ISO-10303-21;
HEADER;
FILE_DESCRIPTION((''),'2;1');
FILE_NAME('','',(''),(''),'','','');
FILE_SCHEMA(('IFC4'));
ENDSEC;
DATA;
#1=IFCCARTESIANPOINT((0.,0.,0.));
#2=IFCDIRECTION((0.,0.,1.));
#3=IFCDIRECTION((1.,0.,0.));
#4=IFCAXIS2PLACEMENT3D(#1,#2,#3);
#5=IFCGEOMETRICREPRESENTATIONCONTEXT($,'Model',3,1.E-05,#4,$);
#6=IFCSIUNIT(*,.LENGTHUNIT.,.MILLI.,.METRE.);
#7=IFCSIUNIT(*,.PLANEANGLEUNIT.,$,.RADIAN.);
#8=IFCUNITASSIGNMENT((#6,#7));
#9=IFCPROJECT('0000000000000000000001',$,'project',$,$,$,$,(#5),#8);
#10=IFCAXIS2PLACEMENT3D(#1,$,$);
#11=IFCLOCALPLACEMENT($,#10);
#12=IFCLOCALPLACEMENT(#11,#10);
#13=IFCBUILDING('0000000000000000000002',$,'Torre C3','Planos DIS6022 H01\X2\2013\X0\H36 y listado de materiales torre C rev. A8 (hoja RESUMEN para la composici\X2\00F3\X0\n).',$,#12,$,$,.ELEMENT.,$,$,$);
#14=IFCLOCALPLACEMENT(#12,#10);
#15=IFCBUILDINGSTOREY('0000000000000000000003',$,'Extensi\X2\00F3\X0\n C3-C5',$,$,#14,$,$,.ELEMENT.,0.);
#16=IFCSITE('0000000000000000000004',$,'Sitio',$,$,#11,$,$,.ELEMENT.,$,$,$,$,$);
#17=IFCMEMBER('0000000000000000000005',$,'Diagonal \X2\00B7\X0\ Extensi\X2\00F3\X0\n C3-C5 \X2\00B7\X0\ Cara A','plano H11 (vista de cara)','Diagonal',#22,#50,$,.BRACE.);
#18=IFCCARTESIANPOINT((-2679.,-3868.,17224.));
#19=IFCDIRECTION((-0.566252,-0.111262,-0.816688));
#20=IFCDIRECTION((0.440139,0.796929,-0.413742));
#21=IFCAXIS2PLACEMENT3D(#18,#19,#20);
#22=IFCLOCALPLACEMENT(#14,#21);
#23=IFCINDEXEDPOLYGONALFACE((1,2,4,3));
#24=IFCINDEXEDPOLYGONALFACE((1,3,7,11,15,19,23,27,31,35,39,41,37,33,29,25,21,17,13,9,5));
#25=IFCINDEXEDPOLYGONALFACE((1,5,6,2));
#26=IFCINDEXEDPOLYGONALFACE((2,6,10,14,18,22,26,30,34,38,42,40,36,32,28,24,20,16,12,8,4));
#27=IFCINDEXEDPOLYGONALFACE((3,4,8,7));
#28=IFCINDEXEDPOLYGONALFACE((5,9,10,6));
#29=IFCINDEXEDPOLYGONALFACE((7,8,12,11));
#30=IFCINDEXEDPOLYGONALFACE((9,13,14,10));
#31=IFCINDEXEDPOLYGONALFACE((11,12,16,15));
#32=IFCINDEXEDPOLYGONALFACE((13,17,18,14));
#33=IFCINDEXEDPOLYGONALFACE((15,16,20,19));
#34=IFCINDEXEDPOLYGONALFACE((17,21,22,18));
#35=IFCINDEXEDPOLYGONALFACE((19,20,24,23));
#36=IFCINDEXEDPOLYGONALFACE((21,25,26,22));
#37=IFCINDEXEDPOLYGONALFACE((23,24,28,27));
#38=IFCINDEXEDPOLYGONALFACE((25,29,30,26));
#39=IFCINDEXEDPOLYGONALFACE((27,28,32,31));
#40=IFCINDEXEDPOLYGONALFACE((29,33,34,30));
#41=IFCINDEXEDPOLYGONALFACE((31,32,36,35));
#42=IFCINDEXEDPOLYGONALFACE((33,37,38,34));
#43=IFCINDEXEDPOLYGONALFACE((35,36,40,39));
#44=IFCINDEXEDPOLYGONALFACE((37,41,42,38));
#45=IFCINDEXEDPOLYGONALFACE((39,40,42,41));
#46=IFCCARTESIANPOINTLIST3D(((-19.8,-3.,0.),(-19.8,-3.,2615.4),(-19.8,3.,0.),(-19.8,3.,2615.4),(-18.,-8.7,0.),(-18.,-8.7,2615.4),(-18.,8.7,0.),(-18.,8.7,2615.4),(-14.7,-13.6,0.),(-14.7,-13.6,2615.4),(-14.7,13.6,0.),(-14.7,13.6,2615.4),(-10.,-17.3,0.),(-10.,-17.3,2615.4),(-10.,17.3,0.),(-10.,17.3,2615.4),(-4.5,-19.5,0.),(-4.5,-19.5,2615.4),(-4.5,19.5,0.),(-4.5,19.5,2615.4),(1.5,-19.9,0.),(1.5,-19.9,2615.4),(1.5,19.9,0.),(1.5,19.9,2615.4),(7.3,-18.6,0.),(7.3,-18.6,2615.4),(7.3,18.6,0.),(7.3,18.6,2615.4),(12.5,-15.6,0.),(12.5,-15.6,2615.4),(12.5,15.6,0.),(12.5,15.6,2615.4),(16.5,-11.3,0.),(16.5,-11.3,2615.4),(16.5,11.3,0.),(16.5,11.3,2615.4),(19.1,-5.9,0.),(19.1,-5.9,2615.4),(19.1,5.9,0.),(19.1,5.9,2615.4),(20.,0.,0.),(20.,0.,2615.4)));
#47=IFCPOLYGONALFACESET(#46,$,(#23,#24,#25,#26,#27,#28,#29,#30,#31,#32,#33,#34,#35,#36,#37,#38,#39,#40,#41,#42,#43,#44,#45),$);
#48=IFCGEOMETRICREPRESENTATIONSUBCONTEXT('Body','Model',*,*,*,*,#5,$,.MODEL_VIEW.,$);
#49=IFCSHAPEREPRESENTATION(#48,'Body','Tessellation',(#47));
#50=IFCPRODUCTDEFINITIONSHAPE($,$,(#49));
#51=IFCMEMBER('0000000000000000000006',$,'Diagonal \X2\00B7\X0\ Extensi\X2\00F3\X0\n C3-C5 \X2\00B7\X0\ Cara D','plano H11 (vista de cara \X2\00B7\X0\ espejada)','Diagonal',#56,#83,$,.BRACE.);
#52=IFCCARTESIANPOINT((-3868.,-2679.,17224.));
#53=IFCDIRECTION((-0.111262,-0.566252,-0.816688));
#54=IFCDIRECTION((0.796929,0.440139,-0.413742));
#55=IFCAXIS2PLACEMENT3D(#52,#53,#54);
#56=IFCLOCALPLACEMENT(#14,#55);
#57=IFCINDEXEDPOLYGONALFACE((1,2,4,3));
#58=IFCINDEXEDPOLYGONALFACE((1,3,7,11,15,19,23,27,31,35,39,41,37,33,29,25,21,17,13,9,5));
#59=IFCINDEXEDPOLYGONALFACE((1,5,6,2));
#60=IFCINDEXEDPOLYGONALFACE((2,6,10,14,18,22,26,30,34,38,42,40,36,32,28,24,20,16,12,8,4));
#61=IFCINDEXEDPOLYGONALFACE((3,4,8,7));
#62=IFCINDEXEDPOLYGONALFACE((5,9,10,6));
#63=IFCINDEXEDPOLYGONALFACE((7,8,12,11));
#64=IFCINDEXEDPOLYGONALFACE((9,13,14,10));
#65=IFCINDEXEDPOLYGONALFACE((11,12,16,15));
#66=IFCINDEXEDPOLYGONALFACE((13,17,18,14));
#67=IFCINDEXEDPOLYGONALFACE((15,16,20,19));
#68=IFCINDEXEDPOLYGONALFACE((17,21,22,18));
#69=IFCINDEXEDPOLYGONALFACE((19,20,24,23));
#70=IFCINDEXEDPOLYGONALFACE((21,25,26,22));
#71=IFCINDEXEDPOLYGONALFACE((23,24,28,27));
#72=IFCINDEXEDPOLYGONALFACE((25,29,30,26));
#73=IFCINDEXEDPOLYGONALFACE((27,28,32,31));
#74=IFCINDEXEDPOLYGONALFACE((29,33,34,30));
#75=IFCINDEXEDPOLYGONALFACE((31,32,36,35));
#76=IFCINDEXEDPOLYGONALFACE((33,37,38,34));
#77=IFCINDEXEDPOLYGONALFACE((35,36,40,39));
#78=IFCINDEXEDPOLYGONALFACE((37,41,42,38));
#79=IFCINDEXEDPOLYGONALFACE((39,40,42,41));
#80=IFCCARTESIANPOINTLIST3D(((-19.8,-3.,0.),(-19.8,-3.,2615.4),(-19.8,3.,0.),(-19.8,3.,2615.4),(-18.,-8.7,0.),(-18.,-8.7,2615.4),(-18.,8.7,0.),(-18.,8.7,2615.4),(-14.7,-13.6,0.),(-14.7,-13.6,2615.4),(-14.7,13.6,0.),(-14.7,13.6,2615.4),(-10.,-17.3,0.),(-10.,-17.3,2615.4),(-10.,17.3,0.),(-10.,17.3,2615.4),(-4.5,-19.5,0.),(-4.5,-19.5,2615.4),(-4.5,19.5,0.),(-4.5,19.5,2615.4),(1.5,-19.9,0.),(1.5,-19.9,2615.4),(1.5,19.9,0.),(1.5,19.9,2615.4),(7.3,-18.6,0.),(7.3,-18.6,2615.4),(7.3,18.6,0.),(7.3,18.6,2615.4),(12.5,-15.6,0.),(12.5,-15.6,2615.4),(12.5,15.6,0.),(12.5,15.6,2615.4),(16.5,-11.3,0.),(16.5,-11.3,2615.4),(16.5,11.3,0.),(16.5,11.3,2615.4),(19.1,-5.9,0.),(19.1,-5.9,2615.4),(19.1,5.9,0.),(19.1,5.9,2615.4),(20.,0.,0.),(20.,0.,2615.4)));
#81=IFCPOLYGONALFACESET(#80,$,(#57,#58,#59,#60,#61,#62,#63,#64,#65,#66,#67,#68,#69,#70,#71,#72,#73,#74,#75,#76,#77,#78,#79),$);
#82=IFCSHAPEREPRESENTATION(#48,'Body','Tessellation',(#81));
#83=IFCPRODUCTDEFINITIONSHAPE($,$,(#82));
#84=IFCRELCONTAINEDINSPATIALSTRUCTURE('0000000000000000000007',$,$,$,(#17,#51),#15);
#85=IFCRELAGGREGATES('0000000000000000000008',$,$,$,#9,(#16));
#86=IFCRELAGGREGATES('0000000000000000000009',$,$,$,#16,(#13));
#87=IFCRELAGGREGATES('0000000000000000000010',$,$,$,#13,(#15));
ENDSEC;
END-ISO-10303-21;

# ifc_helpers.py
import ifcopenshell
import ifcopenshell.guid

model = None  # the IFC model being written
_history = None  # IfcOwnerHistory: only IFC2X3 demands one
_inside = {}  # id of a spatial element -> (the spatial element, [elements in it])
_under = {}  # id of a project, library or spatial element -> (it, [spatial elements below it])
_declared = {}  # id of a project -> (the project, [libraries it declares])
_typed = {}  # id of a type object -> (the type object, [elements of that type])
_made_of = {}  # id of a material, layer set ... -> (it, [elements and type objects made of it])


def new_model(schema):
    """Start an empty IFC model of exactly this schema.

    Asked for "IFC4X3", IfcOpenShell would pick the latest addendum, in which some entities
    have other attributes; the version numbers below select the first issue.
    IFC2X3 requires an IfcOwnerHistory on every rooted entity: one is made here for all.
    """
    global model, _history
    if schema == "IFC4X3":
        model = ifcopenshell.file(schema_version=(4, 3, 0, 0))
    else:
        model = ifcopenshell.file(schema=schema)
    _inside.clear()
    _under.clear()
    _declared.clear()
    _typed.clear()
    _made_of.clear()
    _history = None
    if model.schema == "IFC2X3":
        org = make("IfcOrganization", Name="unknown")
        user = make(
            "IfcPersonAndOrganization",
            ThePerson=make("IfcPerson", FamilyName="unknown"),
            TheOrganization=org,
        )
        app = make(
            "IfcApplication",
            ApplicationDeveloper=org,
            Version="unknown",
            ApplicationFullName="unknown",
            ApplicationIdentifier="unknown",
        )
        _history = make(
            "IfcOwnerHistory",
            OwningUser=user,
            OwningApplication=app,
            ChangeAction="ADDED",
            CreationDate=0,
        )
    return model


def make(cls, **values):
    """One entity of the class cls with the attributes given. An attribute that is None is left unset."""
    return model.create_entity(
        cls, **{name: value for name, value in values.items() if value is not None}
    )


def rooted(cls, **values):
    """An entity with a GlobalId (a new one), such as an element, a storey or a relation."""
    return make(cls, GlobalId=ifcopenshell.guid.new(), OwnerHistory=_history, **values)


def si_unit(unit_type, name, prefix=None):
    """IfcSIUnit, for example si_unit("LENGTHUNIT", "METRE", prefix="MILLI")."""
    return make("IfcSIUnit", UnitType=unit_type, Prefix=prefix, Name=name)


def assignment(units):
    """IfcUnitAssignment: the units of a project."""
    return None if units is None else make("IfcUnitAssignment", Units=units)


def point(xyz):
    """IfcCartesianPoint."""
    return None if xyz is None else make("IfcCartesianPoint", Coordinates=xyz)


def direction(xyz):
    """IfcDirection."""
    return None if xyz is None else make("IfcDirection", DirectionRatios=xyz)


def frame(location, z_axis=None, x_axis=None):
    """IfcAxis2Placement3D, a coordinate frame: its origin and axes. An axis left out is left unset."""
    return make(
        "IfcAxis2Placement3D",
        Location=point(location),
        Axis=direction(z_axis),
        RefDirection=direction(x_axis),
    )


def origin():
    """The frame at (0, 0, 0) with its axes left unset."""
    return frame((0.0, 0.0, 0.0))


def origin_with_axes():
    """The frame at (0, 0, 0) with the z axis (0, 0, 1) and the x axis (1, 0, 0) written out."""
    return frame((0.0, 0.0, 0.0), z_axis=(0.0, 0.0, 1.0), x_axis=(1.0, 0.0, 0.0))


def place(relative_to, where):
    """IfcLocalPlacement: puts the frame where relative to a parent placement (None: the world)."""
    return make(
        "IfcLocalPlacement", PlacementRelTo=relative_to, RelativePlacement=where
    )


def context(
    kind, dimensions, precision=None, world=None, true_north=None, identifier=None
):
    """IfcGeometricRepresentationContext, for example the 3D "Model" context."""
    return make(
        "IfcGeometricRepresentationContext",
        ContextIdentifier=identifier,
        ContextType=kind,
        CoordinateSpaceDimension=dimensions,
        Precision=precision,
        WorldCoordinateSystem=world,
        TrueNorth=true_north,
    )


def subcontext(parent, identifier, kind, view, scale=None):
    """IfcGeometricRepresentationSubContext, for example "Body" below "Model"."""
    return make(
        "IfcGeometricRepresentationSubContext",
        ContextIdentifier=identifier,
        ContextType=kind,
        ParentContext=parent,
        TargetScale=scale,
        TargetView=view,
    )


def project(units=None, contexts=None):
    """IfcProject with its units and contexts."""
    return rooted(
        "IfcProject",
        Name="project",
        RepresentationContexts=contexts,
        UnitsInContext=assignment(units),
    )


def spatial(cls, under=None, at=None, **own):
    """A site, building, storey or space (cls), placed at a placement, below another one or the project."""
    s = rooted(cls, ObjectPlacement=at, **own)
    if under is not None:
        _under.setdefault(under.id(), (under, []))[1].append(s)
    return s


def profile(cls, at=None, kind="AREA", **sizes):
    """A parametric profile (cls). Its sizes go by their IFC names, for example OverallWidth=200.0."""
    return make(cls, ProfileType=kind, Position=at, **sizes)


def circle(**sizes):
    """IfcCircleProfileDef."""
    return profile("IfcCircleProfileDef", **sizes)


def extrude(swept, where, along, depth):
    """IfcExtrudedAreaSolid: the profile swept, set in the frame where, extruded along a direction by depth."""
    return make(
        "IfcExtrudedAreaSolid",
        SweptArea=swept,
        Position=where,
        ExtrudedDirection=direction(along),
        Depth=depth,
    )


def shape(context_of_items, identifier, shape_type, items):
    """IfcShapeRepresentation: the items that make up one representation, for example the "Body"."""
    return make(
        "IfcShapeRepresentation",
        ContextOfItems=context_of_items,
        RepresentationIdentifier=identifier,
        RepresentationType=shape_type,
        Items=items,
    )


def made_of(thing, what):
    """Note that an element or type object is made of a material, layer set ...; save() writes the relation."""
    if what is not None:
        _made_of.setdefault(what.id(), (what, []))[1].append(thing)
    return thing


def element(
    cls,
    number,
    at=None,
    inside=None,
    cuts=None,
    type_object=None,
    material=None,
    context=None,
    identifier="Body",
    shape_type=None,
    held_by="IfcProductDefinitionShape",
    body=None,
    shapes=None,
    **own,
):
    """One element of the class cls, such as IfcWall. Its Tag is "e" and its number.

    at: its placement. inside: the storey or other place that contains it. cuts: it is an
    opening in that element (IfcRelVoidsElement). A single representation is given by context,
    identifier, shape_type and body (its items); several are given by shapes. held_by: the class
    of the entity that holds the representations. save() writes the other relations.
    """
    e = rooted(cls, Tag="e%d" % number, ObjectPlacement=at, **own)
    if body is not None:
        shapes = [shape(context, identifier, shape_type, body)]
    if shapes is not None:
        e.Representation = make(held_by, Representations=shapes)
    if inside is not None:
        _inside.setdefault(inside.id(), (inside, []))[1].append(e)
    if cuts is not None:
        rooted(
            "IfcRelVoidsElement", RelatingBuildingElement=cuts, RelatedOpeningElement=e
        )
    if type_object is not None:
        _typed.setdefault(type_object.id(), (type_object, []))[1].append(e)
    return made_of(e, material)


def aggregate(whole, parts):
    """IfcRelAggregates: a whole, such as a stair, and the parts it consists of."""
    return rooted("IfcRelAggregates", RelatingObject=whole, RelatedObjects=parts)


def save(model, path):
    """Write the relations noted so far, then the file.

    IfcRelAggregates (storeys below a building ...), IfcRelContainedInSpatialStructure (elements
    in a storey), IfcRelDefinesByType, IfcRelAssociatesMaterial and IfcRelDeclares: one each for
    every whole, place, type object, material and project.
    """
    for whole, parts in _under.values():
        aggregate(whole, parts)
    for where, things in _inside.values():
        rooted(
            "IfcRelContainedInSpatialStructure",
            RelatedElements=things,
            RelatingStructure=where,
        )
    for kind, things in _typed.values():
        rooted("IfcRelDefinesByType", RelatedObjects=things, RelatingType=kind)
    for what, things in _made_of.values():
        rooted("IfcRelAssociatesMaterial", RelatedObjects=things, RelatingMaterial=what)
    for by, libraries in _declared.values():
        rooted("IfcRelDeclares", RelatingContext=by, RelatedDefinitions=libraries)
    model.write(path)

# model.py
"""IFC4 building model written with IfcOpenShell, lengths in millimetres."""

from ifc_helpers import new_model, si_unit, frame, origin, origin_with_axes, place, context, subcontext, project, spatial, circle, extrude, element, save


model = new_model("IFC4")

# Units and contexts
model_context = context("Model", 3, precision=1e-05, world=origin_with_axes())
body_context = subcontext(model_context, "Body", "Model", "MODEL_VIEW")
ifc_project = project(units=[si_unit("LENGTHUNIT", "METRE", prefix="MILLI"), si_unit("PLANEANGLEUNIT", "RADIAN")], contexts=[model_context])

# Site, building, storey
site_placement = place(None, origin())
site = spatial("IfcSite", under=ifc_project, at=site_placement, Name="Sitio", CompositionType="ELEMENT")
building_placement = place(site_placement, origin())
building = spatial("IfcBuilding", under=site, at=building_placement, Name="Torre C3", Description="Planos DIS6022 H01–H36 y listado de materiales torre C rev. A8 (hoja RESUMEN para la composición).", CompositionType="ELEMENT")
storey_placement = place(building_placement, origin())
storey = spatial("IfcBuildingStorey", under=building, at=storey_placement, Name="Extensión C3-C5", CompositionType="ELEMENT", Elevation=0.0)

# Members
for number, where, z_axis, x_axis, name, description in (
    (1, (-2679.0, -3868.0, 17224.0), (-0.566252, -0.111262, -0.816688), (0.440139, 0.796929, -0.413742), "Diagonal · Extensión C3-C5 · Cara A", "plano H11 (vista de cara)"),
    (2, (-3868.0, -2679.0, 17224.0), (-0.111262, -0.566252, -0.816688), (0.796929, 0.440139, -0.413742), "Diagonal · Extensión C3-C5 · Cara D", "plano H11 (vista de cara · espejada)"),
):
    element("IfcMember", number, at=place(storey_placement, frame(where, z_axis=z_axis, x_axis=x_axis)), inside=storey, Name=name, Description=description, ObjectType="Diagonal", PredefinedType="BRACE", context=body_context, shape_type="SweptSolid", body=[
        extrude(circle(Radius=20.0), None, (0.0, 0.0, 1.0), 2615.4),
    ])

save(model, "model.ifc")
